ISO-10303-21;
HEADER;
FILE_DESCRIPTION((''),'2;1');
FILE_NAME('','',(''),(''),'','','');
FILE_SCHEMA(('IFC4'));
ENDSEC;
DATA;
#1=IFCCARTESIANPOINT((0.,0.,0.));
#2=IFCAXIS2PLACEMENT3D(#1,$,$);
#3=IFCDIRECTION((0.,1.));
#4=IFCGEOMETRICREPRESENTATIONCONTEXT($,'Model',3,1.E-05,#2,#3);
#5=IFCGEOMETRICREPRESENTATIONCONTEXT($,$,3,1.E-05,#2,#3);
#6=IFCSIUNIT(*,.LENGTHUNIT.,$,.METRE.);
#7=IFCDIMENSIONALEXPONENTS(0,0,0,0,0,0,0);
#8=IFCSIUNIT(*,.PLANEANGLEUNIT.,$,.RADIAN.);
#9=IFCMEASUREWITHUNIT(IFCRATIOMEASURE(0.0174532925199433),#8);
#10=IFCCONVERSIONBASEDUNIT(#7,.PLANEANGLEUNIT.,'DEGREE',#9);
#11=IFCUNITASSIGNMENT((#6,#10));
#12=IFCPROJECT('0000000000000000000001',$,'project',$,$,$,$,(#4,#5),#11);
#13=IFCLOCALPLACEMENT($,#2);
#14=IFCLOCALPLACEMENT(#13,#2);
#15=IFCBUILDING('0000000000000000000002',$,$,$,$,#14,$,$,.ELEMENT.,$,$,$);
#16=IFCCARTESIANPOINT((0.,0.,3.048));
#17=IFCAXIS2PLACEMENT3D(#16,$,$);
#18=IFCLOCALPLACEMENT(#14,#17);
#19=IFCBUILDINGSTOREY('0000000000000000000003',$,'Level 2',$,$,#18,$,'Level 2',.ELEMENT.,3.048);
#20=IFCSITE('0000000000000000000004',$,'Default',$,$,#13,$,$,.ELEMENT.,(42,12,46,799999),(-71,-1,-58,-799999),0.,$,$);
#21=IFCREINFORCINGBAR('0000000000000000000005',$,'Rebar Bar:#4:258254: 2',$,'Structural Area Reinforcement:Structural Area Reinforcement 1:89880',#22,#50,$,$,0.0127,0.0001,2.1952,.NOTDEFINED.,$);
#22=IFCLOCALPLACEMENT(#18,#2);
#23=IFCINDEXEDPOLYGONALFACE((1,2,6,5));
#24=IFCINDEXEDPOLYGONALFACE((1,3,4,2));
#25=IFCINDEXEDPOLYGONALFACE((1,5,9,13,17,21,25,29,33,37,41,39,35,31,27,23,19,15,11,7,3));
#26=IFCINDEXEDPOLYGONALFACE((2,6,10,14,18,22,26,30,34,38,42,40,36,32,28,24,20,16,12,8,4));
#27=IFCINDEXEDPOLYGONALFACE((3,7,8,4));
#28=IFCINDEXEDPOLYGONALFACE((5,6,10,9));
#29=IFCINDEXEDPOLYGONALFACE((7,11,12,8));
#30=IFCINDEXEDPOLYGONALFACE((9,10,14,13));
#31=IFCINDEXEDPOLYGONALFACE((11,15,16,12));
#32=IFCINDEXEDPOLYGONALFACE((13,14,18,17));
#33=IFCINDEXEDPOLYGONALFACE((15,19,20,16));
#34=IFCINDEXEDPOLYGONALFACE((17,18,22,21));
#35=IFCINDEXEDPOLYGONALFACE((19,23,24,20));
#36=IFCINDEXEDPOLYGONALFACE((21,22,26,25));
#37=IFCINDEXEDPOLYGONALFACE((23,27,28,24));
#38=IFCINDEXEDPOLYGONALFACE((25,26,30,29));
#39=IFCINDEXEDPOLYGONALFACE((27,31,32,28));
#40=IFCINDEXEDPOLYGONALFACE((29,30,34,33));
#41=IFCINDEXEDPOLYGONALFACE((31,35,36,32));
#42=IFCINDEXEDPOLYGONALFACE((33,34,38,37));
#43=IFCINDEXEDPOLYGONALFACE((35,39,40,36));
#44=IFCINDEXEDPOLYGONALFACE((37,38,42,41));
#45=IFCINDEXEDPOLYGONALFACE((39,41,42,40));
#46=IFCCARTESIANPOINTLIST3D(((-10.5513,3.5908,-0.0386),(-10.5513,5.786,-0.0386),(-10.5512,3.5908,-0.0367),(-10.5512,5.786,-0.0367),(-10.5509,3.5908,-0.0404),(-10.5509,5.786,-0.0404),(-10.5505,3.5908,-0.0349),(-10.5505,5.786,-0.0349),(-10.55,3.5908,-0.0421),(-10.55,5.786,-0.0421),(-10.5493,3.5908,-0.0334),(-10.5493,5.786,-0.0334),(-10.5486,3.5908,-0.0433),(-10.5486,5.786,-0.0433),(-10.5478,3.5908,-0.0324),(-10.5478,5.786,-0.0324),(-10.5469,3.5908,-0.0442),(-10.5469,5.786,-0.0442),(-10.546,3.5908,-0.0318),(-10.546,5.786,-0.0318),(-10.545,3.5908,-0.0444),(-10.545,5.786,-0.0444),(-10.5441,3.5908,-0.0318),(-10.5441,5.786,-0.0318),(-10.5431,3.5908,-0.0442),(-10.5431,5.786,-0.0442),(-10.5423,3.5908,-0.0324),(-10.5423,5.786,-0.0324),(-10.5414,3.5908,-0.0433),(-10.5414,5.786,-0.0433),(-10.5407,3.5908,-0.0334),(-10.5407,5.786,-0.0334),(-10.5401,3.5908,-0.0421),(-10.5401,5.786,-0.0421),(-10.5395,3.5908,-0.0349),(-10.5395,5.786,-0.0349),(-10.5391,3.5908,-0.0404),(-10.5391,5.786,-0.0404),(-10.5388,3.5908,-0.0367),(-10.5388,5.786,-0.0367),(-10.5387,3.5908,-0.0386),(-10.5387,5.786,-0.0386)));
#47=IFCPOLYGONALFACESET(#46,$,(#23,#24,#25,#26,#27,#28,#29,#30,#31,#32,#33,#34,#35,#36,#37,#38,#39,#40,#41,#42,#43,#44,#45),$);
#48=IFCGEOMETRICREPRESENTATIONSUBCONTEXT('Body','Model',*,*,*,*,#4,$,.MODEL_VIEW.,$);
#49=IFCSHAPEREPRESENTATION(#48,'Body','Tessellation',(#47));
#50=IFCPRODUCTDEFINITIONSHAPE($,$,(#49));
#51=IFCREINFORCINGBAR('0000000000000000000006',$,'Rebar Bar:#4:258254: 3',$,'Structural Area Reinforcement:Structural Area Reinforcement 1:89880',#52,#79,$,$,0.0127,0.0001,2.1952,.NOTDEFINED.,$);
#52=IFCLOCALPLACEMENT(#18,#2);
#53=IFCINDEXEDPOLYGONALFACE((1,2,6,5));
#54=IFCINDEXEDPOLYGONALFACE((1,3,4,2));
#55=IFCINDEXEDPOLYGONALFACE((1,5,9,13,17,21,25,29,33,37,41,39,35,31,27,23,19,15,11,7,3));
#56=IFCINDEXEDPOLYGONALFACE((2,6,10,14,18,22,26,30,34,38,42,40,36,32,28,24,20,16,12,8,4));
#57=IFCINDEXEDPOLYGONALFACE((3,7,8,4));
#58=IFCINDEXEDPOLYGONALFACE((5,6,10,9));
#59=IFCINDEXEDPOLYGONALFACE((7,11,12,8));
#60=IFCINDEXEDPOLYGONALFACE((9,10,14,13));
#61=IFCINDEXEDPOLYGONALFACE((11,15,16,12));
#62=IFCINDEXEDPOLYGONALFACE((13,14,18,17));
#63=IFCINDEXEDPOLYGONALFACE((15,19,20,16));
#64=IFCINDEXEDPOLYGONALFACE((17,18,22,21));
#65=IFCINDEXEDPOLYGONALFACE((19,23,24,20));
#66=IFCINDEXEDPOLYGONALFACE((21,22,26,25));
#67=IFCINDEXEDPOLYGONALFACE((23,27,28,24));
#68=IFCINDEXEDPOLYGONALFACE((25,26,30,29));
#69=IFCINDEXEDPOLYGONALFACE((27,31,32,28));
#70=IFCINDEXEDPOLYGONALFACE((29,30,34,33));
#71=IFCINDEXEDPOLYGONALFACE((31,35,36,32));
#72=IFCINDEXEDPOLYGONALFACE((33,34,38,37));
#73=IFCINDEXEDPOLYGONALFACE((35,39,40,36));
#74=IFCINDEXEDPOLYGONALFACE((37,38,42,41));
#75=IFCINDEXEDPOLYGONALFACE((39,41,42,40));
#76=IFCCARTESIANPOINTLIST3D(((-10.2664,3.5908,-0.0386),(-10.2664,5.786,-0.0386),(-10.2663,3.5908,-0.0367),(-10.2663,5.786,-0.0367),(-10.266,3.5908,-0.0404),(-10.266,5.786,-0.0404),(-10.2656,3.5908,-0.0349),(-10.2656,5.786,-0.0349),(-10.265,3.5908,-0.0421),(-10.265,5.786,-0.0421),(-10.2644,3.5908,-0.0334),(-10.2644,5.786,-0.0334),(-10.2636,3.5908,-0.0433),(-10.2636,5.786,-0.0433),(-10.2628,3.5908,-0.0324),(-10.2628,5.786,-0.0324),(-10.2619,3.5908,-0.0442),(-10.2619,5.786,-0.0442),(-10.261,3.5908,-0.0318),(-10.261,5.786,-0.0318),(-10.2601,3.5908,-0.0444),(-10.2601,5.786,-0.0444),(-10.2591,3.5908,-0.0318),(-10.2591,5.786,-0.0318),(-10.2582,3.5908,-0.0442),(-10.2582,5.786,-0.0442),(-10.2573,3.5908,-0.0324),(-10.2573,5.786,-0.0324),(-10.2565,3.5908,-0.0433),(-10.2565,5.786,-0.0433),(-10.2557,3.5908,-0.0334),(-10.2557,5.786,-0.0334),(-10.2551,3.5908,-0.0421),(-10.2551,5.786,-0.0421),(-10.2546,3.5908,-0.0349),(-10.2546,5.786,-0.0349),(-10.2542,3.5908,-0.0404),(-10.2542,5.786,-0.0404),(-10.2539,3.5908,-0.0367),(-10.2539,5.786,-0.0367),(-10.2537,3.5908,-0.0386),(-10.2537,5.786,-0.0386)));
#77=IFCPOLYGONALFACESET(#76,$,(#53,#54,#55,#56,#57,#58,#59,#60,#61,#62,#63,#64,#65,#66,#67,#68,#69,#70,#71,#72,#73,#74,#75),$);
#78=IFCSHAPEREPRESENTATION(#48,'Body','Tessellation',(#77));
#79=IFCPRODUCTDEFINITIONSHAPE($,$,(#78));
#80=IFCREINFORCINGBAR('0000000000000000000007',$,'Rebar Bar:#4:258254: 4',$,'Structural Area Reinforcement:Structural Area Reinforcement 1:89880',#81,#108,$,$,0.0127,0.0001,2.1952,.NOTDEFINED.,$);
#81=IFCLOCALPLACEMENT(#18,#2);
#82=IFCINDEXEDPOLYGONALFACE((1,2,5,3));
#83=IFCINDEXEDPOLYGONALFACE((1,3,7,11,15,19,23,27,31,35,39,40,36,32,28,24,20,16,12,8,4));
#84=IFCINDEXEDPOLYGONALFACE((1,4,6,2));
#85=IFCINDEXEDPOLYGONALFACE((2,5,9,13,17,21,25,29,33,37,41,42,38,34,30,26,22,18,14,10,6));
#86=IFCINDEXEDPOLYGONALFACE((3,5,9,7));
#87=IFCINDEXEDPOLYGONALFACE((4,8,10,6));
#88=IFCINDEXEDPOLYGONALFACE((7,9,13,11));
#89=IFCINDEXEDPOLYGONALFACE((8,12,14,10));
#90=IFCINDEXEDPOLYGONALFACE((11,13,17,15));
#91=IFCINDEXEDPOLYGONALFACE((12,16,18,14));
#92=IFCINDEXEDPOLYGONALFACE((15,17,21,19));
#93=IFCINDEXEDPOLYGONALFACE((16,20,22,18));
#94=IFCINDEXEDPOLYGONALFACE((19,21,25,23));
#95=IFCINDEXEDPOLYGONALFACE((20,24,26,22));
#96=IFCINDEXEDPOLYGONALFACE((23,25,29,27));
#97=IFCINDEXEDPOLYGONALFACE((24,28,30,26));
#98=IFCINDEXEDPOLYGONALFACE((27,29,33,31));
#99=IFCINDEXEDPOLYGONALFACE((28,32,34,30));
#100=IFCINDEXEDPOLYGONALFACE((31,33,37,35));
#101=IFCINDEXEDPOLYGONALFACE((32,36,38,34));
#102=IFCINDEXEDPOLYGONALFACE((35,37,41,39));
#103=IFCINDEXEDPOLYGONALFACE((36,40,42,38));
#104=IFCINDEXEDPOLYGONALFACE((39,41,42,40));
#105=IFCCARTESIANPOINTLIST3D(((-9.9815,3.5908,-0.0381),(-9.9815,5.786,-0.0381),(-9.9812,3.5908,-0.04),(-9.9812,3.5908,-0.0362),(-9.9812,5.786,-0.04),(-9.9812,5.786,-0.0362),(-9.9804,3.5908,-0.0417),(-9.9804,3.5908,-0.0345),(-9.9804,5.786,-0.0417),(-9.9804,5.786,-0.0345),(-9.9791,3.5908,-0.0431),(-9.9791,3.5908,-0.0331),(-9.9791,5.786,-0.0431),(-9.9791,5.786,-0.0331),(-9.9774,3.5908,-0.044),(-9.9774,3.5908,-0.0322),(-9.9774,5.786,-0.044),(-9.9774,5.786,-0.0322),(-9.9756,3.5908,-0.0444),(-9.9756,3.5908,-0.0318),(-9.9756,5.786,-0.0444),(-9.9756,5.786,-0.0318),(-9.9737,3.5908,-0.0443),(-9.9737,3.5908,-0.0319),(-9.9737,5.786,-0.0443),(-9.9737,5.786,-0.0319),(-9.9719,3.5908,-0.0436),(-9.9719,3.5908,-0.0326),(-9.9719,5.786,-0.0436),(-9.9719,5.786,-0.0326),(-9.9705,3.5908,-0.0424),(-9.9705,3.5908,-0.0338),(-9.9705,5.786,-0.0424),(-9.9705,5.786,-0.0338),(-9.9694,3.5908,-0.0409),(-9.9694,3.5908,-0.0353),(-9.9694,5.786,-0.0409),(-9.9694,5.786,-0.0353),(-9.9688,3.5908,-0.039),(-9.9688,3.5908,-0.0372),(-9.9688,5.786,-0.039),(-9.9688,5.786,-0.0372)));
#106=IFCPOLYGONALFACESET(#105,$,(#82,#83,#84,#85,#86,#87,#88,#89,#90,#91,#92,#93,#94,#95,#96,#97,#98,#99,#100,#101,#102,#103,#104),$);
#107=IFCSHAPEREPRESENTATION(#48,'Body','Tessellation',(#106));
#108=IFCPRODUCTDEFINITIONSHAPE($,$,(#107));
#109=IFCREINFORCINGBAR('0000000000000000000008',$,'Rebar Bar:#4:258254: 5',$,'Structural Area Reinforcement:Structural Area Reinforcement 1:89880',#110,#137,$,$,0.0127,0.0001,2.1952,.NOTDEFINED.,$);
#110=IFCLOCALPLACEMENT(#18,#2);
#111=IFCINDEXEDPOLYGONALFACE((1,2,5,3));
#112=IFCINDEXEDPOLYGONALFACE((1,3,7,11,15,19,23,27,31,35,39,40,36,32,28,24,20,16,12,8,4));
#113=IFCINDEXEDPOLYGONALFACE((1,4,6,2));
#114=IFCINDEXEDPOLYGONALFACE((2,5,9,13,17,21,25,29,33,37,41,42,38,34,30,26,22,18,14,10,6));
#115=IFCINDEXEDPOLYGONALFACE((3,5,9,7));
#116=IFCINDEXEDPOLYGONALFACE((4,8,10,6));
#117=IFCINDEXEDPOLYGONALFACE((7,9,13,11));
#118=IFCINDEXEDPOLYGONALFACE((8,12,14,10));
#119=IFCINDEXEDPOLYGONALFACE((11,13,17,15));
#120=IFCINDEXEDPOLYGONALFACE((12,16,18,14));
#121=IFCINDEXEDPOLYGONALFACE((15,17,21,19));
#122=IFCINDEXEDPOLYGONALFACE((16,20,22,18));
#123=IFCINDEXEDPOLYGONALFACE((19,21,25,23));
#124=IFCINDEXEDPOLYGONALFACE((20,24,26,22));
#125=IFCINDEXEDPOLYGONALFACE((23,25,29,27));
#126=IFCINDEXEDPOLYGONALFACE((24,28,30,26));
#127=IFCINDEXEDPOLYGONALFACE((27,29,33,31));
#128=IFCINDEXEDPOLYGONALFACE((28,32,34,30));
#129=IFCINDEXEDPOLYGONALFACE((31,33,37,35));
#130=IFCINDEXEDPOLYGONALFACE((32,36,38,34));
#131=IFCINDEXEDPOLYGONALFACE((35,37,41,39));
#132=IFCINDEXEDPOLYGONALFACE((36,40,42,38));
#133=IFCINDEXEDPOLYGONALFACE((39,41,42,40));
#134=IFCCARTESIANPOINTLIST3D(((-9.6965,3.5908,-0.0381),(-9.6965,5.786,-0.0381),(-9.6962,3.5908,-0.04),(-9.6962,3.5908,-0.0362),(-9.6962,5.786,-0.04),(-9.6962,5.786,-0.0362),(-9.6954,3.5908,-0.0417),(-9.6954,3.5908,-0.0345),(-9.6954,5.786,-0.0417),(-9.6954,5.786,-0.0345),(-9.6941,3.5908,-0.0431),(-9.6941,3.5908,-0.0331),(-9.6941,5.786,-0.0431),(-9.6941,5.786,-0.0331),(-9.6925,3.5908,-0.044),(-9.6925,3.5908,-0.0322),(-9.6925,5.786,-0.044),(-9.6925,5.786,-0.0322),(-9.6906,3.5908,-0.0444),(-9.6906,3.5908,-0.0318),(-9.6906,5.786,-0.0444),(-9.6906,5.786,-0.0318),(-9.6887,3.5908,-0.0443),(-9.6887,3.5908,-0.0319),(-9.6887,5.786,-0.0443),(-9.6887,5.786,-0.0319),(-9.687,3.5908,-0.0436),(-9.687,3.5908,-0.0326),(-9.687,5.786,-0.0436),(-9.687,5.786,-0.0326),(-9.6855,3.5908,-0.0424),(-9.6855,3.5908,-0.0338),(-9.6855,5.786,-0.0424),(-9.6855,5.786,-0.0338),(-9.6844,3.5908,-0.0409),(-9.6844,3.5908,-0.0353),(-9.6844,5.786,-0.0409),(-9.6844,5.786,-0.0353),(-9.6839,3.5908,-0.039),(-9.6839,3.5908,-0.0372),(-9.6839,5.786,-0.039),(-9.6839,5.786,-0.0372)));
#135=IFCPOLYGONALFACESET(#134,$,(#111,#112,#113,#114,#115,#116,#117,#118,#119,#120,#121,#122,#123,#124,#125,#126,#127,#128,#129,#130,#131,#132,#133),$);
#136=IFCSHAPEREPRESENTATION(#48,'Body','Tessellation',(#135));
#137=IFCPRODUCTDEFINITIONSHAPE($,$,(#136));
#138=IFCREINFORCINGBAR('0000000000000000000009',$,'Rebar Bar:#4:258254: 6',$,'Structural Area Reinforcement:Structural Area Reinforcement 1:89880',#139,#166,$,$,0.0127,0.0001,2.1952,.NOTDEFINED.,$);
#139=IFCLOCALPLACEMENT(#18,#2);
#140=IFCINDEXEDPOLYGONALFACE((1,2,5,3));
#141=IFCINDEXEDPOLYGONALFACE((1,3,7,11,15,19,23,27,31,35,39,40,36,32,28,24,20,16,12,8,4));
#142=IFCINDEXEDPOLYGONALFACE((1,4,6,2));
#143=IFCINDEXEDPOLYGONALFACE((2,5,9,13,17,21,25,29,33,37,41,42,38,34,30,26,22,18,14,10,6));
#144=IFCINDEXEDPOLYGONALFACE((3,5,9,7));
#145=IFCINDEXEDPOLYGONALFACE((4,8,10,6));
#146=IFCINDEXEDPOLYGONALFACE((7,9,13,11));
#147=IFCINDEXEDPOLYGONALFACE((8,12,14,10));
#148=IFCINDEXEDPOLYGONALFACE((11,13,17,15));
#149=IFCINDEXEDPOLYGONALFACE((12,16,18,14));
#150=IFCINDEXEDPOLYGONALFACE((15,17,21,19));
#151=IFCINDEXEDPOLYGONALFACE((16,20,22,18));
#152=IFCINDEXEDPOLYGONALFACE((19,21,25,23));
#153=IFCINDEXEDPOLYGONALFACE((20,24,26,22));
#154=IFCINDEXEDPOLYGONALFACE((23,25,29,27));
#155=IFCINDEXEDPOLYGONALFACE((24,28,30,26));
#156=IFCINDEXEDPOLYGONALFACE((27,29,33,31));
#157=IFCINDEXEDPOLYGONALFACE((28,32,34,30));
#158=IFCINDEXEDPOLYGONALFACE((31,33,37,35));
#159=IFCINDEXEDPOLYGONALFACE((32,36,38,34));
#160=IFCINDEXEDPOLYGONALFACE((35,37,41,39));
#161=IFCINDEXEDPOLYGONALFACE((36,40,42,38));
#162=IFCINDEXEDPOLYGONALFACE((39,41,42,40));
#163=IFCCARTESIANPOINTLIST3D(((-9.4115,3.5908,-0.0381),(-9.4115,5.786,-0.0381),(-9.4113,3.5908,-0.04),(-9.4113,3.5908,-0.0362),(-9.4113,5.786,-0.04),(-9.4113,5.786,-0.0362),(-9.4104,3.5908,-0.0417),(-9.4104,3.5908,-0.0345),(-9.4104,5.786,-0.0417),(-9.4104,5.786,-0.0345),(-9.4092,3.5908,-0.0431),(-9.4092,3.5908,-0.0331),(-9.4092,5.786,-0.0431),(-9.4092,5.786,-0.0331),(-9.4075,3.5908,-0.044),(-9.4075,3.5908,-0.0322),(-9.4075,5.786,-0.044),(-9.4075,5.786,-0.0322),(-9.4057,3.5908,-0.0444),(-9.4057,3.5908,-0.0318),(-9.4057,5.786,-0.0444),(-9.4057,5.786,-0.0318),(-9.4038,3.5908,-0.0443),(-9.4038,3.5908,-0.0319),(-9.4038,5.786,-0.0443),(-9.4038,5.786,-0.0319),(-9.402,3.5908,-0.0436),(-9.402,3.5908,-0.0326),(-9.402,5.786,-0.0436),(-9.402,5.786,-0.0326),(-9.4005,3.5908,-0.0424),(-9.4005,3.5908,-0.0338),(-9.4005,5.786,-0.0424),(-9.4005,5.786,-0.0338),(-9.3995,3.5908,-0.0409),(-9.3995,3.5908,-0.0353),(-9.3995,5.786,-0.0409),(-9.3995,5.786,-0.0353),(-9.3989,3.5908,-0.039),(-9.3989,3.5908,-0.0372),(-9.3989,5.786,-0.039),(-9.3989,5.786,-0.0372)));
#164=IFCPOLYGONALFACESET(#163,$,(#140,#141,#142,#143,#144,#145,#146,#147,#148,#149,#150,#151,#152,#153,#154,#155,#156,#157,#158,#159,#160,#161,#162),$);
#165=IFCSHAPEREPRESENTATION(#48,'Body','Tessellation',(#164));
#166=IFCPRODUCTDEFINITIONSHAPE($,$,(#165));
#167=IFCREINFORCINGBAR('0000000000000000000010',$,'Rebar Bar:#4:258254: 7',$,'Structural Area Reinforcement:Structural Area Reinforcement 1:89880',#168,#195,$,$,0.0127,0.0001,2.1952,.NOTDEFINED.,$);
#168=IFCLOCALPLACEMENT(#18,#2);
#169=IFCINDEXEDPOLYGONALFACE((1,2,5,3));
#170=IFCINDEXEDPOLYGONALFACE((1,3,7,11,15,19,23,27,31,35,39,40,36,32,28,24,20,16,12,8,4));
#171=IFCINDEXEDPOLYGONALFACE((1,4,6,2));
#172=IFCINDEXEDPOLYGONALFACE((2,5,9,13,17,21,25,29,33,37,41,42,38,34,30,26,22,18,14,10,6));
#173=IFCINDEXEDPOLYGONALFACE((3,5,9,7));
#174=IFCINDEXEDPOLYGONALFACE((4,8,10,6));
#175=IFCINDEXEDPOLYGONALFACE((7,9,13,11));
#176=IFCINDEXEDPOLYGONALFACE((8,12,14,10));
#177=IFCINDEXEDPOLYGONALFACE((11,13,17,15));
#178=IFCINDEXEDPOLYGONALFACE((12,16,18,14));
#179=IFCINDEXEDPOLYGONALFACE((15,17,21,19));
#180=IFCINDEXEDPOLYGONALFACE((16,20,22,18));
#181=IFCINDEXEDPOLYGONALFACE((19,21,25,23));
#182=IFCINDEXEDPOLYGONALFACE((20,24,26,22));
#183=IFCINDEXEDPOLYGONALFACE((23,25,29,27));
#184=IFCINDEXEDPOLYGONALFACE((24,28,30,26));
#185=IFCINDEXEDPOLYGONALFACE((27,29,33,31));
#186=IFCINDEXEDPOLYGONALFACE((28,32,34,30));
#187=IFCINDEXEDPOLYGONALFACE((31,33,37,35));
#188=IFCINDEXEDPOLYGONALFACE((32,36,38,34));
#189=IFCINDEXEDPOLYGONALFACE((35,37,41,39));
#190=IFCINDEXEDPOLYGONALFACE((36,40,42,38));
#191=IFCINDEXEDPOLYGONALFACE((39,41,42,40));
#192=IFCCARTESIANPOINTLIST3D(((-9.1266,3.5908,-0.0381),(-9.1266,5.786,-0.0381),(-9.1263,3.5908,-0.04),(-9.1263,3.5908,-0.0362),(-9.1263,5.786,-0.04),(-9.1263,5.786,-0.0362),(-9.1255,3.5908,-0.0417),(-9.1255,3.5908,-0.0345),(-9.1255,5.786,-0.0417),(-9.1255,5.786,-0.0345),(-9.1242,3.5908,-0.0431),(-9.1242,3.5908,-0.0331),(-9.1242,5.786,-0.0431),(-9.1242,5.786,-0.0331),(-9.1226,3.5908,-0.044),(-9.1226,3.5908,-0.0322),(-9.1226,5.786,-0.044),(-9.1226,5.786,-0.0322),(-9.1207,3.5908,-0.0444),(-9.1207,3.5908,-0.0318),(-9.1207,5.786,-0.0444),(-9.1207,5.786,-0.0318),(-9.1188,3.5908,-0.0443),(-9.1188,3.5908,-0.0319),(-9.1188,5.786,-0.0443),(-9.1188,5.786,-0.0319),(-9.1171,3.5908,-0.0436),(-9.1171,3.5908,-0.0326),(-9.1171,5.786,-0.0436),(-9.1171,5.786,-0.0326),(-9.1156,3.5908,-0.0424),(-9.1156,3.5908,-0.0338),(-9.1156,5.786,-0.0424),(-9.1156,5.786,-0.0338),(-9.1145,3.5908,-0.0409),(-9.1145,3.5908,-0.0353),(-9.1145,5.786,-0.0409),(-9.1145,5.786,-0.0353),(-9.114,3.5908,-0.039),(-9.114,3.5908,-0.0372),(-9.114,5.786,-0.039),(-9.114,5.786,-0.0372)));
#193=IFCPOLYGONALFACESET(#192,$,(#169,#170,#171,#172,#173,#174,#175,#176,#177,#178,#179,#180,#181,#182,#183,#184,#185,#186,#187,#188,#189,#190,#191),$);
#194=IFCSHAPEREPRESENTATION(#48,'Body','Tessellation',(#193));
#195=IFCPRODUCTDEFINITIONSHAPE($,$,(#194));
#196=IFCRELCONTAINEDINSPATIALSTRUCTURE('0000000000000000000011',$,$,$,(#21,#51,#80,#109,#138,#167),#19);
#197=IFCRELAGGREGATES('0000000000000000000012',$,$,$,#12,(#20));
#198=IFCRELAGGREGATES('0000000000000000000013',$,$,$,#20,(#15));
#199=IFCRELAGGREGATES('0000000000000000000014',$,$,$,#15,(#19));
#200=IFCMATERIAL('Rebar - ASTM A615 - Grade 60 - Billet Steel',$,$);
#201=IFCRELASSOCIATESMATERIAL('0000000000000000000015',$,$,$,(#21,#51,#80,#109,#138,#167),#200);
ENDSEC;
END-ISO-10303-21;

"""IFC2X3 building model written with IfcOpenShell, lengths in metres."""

from ifc_helpers import new_model, entity, si_unit, converted_unit, direction, frame, origin, place, context, subcontext, project, spatial, material, element, save


model = new_model("IFC2X3")

# Units and contexts
model_context = context("Model", 3, precision=1e-05, world=origin(), true_north=direction((0.0, 1.0)))
context_of_model = context(None, 3, precision=1e-05, world=origin(), true_north=direction((0.0, 1.0)))
body_context = subcontext(model_context, "Body", "Model", "MODEL_VIEW")
ifc_project = project(units=[si_unit("LENGTHUNIT", "METRE"), converted_unit("PLANEANGLEUNIT", "DEGREE", entity("IfcRatioMeasure", 0.0174532925199433), si_unit("PLANEANGLEUNIT", "RADIAN"), dimensions=[0, 0, 0, 0, 0, 0, 0])], contexts=[model_context, context_of_model])

# Site, building, storey
site_placement = place(None, origin())
site = spatial("IfcSite", under=ifc_project, at=site_placement, Name="Default", CompositionType="ELEMENT", RefLatitude=(42, 12, 46, 799999), RefLongitude=(-71, -1, -58, -799999), RefElevation=0.0)
building_placement = place(site_placement, origin())
building = spatial("IfcBuilding", under=site, at=building_placement, CompositionType="ELEMENT")
storey_placement = place(building_placement, frame((0.0, 0.0, 3.048)))
storey = spatial("IfcBuildingStorey", under=building, at=storey_placement, Name="Level 2", LongName="Level 2", CompositionType="ELEMENT", Elevation=3.048)

# Reinforcing bars
ifc_material_1 = material(Name="Rebar - ASTM A615 - Grade 60 - Billet Steel")
reinforcing_bar_1_placement = place(storey_placement, origin())
element("IfcReinforcingBar", 1, at=reinforcing_bar_1_placement, inside=storey, material=ifc_material_1, Name="Rebar Bar:#4:258254: 2", ObjectType="Structural Area Reinforcement:Structural Area Reinforcement 1:89880", BarLength=2.1952, BarRole="NOTDEFINED", CrossSectionArea=0.0001, NominalDiameter=0.0127, context=body_context, shape_type="AdvancedSweptSolid", body=[
    entity("IfcSweptDiskSolid", entity("IfcCompositeCurve", [entity("IfcCompositeCurveSegment", "CONTINUOUS", True, entity("IfcPolyline", [entity("IfcCartesianPoint", [-10.545, 5.786, -0.0381]), entity("IfcCartesianPoint", [-10.545, 3.5908, -0.0381])]))], False), 0.0063, None, 0.0, 1.0),
])
reinforcing_bar_2_placement = place(storey_placement, origin())
element("IfcReinforcingBar", 2, at=reinforcing_bar_2_placement, inside=storey, material=ifc_material_1, Name="Rebar Bar:#4:258254: 3", ObjectType="Structural Area Reinforcement:Structural Area Reinforcement 1:89880", BarLength=2.1952, BarRole="NOTDEFINED", CrossSectionArea=0.0001, NominalDiameter=0.0127, context=body_context, shape_type="AdvancedSweptSolid", body=[
    entity("IfcSweptDiskSolid", entity("IfcCompositeCurve", [entity("IfcCompositeCurveSegment", "CONTINUOUS", True, entity("IfcPolyline", [entity("IfcCartesianPoint", [-10.2601, 5.786, -0.0381]), entity("IfcCartesianPoint", [-10.2601, 3.5908, -0.0381])]))], False), 0.0063, None, 0.0, 1.0),
])
reinforcing_bar_3_placement = place(storey_placement, origin())
element("IfcReinforcingBar", 3, at=reinforcing_bar_3_placement, inside=storey, material=ifc_material_1, Name="Rebar Bar:#4:258254: 4", ObjectType="Structural Area Reinforcement:Structural Area Reinforcement 1:89880", BarLength=2.1952, BarRole="NOTDEFINED", CrossSectionArea=0.0001, NominalDiameter=0.0127, context=body_context, shape_type="AdvancedSweptSolid", body=[
    entity("IfcSweptDiskSolid", entity("IfcCompositeCurve", [entity("IfcCompositeCurveSegment", "CONTINUOUS", True, entity("IfcPolyline", [entity("IfcCartesianPoint", [-9.9751, 5.786, -0.0381]), entity("IfcCartesianPoint", [-9.9751, 3.5908, -0.0381])]))], False), 0.0063, None, 0.0, 1.0),
])
reinforcing_bar_4_placement = place(storey_placement, origin())
element("IfcReinforcingBar", 4, at=reinforcing_bar_4_placement, inside=storey, material=ifc_material_1, Name="Rebar Bar:#4:258254: 5", ObjectType="Structural Area Reinforcement:Structural Area Reinforcement 1:89880", BarLength=2.1952, BarRole="NOTDEFINED", CrossSectionArea=0.0001, NominalDiameter=0.0127, context=body_context, shape_type="AdvancedSweptSolid", body=[
    entity("IfcSweptDiskSolid", entity("IfcCompositeCurve", [entity("IfcCompositeCurveSegment", "CONTINUOUS", True, entity("IfcPolyline", [entity("IfcCartesianPoint", [-9.6901, 5.786, -0.0381]), entity("IfcCartesianPoint", [-9.6901, 3.5908, -0.0381])]))], False), 0.0063, None, 0.0, 1.0),
])
reinforcing_bar_5_placement = place(storey_placement, origin())
element("IfcReinforcingBar", 5, at=reinforcing_bar_5_placement, inside=storey, material=ifc_material_1, Name="Rebar Bar:#4:258254: 6", ObjectType="Structural Area Reinforcement:Structural Area Reinforcement 1:89880", BarLength=2.1952, BarRole="NOTDEFINED", CrossSectionArea=0.0001, NominalDiameter=0.0127, context=body_context, shape_type="AdvancedSweptSolid", body=[
    entity("IfcSweptDiskSolid", entity("IfcCompositeCurve", [entity("IfcCompositeCurveSegment", "CONTINUOUS", True, entity("IfcPolyline", [entity("IfcCartesianPoint", [-9.4052, 5.786, -0.0381]), entity("IfcCartesianPoint", [-9.4052, 3.5908, -0.0381])]))], False), 0.0063, None, 0.0, 1.0),
])
reinforcing_bar_6_placement = place(storey_placement, origin())
element("IfcReinforcingBar", 6, at=reinforcing_bar_6_placement, inside=storey, material=ifc_material_1, Name="Rebar Bar:#4:258254: 7", ObjectType="Structural Area Reinforcement:Structural Area Reinforcement 1:89880", BarLength=2.1952, BarRole="NOTDEFINED", CrossSectionArea=0.0001, NominalDiameter=0.0127, context=body_context, shape_type="AdvancedSweptSolid", body=[
    entity("IfcSweptDiskSolid", entity("IfcCompositeCurve", [entity("IfcCompositeCurveSegment", "CONTINUOUS", True, entity("IfcPolyline", [entity("IfcCartesianPoint", [-9.1202, 5.786, -0.0381]), entity("IfcCartesianPoint", [-9.1202, 3.5908, -0.0381])]))], False), 0.0063, None, 0.0, 1.0),
])

save(model, "model.ifc")
